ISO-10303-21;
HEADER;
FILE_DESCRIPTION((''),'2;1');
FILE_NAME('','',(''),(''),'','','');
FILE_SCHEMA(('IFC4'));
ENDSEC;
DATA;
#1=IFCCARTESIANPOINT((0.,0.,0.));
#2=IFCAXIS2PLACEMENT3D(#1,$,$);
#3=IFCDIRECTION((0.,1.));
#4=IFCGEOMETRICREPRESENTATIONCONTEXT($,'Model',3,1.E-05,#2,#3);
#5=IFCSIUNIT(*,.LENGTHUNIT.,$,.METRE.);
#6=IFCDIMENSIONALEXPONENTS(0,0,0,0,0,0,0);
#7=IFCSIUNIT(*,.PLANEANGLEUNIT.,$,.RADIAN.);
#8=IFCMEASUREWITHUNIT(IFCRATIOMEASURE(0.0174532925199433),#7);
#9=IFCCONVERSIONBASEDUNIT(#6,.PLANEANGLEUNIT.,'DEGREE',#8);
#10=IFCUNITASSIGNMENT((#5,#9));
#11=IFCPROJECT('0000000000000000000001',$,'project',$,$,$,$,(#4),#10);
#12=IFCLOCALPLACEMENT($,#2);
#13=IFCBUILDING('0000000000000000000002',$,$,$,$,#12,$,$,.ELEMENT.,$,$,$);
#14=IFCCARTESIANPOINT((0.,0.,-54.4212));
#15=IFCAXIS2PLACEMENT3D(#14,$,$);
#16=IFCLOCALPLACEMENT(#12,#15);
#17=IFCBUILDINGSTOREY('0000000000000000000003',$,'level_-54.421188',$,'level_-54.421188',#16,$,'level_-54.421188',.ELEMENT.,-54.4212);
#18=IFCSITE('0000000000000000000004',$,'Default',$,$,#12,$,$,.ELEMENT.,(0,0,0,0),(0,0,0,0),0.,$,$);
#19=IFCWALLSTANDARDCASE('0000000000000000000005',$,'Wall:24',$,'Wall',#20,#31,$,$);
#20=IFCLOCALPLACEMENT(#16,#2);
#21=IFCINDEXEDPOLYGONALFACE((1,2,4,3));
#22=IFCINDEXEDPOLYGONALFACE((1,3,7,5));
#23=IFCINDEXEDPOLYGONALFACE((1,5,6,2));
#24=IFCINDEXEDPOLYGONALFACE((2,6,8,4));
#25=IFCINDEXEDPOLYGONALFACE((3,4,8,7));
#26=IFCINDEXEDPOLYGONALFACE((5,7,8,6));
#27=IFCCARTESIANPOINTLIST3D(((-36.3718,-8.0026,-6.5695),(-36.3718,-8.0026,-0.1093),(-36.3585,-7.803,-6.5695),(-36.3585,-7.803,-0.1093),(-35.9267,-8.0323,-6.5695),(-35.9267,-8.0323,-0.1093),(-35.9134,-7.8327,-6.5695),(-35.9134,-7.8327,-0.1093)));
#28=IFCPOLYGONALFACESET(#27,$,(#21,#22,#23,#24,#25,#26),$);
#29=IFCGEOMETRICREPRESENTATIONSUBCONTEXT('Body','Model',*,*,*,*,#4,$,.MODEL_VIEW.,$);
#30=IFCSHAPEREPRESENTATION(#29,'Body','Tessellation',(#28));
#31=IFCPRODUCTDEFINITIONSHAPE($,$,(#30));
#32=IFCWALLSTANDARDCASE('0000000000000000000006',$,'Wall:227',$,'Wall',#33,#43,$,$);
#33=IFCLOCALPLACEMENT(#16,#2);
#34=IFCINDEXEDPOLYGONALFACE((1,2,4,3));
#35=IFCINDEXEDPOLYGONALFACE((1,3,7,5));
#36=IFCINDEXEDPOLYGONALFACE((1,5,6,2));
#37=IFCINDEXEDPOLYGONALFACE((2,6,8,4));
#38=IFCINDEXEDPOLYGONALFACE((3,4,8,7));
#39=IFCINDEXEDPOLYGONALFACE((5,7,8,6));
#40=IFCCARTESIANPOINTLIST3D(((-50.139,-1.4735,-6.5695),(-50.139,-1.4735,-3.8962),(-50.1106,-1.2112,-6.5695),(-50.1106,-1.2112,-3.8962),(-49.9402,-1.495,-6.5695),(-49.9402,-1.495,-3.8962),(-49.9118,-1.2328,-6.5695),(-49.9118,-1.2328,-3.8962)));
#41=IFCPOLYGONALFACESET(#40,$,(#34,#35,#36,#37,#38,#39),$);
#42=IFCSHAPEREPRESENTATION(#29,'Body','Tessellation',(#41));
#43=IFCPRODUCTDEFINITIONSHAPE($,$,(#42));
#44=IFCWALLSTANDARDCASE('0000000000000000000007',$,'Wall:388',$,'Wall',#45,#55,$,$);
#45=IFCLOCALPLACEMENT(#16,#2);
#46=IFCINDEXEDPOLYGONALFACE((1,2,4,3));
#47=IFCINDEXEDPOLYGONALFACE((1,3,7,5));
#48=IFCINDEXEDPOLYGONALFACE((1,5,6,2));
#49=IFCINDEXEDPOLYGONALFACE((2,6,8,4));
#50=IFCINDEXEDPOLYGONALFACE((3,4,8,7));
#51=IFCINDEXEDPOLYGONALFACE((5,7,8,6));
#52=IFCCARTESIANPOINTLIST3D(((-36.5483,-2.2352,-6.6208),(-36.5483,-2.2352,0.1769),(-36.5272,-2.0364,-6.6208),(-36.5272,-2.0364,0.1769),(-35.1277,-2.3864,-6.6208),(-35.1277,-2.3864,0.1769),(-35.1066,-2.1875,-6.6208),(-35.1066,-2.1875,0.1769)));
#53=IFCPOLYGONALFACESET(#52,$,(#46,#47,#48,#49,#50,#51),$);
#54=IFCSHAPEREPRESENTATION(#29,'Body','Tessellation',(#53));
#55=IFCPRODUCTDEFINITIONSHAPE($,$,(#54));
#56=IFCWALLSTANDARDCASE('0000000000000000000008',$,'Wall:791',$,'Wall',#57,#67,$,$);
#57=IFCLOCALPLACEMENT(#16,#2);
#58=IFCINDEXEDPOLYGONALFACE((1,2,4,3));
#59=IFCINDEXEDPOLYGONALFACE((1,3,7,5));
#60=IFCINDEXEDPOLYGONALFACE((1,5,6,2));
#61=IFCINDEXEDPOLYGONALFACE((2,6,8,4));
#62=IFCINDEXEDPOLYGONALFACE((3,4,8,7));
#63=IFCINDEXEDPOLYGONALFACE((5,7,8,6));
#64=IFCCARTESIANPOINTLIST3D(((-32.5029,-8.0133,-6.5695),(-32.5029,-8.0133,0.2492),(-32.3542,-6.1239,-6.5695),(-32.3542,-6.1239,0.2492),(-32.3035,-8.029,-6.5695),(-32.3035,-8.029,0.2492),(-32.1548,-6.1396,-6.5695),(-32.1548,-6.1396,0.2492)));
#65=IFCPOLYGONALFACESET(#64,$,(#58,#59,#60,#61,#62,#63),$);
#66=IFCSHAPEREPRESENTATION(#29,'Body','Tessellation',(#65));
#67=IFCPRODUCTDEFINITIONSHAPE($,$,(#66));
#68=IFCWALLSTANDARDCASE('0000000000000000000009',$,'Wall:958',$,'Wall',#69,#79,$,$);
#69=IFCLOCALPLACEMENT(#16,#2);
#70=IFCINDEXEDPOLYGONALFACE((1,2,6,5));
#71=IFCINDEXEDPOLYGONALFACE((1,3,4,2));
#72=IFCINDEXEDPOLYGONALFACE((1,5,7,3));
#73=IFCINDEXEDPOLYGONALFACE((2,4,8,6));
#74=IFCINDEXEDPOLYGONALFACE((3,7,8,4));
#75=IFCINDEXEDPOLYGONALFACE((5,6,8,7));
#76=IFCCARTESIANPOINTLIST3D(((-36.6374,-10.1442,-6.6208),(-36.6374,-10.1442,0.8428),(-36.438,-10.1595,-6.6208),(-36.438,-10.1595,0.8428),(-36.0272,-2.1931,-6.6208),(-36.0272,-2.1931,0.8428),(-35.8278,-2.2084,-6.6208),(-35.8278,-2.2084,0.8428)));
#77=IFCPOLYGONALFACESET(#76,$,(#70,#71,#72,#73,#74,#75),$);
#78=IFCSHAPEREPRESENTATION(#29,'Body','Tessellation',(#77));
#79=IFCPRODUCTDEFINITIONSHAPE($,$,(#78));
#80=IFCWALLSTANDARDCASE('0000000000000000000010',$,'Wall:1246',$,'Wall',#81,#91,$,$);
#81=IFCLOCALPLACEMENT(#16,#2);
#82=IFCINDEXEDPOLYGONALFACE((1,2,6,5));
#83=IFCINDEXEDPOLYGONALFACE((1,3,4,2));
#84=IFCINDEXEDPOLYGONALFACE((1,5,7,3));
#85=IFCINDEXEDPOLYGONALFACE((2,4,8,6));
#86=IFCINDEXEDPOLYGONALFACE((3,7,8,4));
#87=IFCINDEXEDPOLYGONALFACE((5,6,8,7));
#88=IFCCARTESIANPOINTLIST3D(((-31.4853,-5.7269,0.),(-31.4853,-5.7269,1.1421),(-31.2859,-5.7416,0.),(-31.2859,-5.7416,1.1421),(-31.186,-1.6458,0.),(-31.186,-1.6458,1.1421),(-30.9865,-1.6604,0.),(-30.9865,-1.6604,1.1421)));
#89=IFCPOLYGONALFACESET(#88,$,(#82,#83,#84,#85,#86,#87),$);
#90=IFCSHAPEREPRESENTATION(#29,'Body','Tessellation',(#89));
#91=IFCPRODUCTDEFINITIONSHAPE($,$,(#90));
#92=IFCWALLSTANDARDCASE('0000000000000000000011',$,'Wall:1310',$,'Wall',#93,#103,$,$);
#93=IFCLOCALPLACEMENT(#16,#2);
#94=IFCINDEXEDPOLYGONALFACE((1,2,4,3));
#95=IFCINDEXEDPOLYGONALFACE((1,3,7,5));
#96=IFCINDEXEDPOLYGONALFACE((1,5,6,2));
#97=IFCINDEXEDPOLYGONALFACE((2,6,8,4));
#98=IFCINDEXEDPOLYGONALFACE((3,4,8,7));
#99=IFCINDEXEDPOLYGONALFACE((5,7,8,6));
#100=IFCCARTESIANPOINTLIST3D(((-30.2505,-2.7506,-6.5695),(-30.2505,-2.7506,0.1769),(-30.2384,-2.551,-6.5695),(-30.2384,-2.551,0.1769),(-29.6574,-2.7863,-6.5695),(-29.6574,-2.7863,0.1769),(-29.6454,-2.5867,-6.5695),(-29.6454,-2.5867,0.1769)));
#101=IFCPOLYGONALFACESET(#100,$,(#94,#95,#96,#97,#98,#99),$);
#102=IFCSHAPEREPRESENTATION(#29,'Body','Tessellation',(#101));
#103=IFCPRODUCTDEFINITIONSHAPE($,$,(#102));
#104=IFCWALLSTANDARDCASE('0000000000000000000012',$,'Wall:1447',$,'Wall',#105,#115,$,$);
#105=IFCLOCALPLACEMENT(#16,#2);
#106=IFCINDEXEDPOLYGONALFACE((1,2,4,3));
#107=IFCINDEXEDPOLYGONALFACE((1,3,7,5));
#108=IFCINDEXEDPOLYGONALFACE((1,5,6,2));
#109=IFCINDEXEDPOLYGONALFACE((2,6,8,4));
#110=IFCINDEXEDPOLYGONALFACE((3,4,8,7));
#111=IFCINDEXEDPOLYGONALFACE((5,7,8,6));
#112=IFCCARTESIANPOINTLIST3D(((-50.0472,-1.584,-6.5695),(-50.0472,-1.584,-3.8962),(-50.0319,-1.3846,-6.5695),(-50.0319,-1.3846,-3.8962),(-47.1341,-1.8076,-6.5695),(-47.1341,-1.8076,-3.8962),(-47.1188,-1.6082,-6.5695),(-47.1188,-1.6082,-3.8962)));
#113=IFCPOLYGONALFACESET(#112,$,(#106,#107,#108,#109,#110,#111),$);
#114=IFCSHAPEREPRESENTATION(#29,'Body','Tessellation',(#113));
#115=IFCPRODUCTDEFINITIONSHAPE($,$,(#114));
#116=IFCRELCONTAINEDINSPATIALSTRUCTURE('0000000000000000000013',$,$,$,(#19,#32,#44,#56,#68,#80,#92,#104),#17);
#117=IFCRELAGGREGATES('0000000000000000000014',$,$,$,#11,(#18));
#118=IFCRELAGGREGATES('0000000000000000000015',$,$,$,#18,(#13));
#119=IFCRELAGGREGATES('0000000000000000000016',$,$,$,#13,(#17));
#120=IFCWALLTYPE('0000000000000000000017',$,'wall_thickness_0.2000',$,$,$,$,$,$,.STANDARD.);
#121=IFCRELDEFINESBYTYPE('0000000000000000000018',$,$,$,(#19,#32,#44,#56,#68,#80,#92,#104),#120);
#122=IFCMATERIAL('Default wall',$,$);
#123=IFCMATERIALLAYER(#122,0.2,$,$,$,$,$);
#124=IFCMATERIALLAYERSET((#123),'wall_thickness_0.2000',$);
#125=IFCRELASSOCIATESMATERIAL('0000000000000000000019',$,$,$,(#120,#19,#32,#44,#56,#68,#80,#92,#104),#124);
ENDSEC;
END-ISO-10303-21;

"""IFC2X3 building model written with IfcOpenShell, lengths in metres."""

from ifc_helpers import new_model, entity, si_unit, converted_unit, direction, frame, origin, place, context, subcontext, project, spatial, polyline, outline, extrude, material, layer, layer_set, layer_usage, type_object, element, save


model = new_model("IFC2X3")

# Units and contexts
model_context = context("Model", 3, precision=1e-05, world=origin(), true_north=direction((0.0, 1.0)))
body_context = subcontext(model_context, "Body", "Model", "MODEL_VIEW")
ifc_project = project(units=[si_unit("LENGTHUNIT", "METRE"), converted_unit("PLANEANGLEUNIT", "DEGREE", entity("IfcRatioMeasure", 0.0174532925199433), si_unit("PLANEANGLEUNIT", "RADIAN"), dimensions=[0, 0, 0, 0, 0, 0, 0])], contexts=[model_context])

# Site, building, storey
placement_1 = place(None, origin())
site = spatial("IfcSite", under=ifc_project, at=placement_1, Name="Default", CompositionType="ELEMENT", RefLatitude=(0, 0, 0, 0), RefLongitude=(0, 0, 0, 0), RefElevation=0.0)
building = spatial("IfcBuilding", under=site, at=placement_1, CompositionType="ELEMENT")
storey_placement = place(placement_1, frame((0.0, 0.0, -54.4212)))
storey = spatial("IfcBuildingStorey", under=building, at=storey_placement, Name="level_-54.421188", ObjectType="level_-54.421188", LongName="level_-54.421188", CompositionType="ELEMENT", Elevation=-54.4212)

# Walls
ifc_material_1 = material(Name="Default wall")
ifc_layer = layer(ifc_material_1, 0.2)
ifc_layer_set = layer_set([ifc_layer], Name="wall_thickness_0.2000")
ifc_layer_usage = layer_usage(ifc_layer_set, "AXIS2", "POSITIVE", -0.1)
wall_type = type_object("IfcWallType", Name="wall_thickness_0.2000", PredefinedType="STANDARD", material=ifc_layer_set)
placement_2 = place(placement_1, frame((0.0, 0.0, -60.9907)))
wall_1_placement = place(placement_2, frame((-35.9201, -7.9325, 0.0), z_axis=(0.0, 0.0, 1.0), x_axis=(-0.997776, 0.066649, 0.0)))
element("IfcWallStandardCase", 1, at=wall_1_placement, inside=storey, type_object=wall_type, material=ifc_layer_usage, Name="Wall:24", ObjectType="Wall", context=body_context, shape_type="SweptSolid", body=[
    extrude(outline(polyline([(0.4461, -0.1), (0.4461, 0.1), (0.0, 0.1), (0.0, -0.1), (0.4461, -0.1)])), origin(), (0.0, 0.0, 1.0), 6.4602),
])
placement_3 = place(placement_1, frame((0.0, 0.0, -60.9907)))
wall_2_placement = place(placement_3, frame((-50.0396, -1.4843, 0.0), z_axis=(0.0, 0.0, 1.0), x_axis=(0.107726, 0.994181, 0.0)))
element("IfcWallStandardCase", 2, at=wall_2_placement, inside=storey, type_object=wall_type, material=ifc_layer_usage, Name="Wall:227", ObjectType="Wall", context=body_context, shape_type="SweptSolid", body=[
    extrude(outline(polyline([(0.2638, -0.1), (0.2638, 0.1), (0.0, 0.1), (0.0, -0.1), (0.2638, -0.1)])), origin(), (0.0, 0.0, 1.0), 2.6733),
])
placement_4 = place(placement_1, frame((0.0, 0.0, -61.042)))
wall_3_placement = place(placement_4, frame((-35.1172, -2.2869, 0.0), z_axis=(0.0, 0.0, 1.0), x_axis=(-0.99439, 0.105778, 0.0)))
element("IfcWallStandardCase", 3, at=wall_3_placement, inside=storey, type_object=wall_type, material=ifc_layer_usage, Name="Wall:388", ObjectType="Wall", context=body_context, shape_type="SweptSolid", body=[
    extrude(outline(polyline([(1.4286, -0.1), (1.4286, 0.1), (0.0, 0.1), (0.0, -0.1), (1.4286, -0.1)])), origin(), (0.0, 0.0, 1.0), 6.7978),
])
placement_5 = place(placement_1, frame((0.0, 0.0, -60.9907)))
wall_4_placement = place(placement_5, frame((-32.2545, -6.1318, 0.0), z_axis=(0.0, 0.0, 1.0), x_axis=(-0.078422, -0.99692, 0.0)))
element("IfcWallStandardCase", 4, at=wall_4_placement, inside=storey, type_object=wall_type, material=ifc_layer_usage, Name="Wall:791", ObjectType="Wall", context=body_context, shape_type="SweptSolid", body=[
    extrude(outline(polyline([(1.8952, -0.1), (1.8952, 0.1), (0.0, 0.1), (0.0, -0.1), (1.8952, -0.1)])), origin(), (0.0, 0.0, 1.0), 6.8187),
])
placement_6 = place(placement_1, frame((0.0, 0.0, -61.042)))
wall_5_placement = place(placement_6, frame((-35.9275, -2.2007, 0.0), z_axis=(0.0, 0.0, 1.0), x_axis=(-0.076521, -0.997068, 0.0)))
element("IfcWallStandardCase", 5, at=wall_5_placement, inside=storey, type_object=wall_type, material=ifc_layer_usage, Name="Wall:958", ObjectType="Wall", context=body_context, shape_type="SweptSolid", body=[
    extrude(outline(polyline([(7.9745, -0.1), (7.9745, 0.1), (0.0, 0.1), (0.0, -0.1), (7.9745, -0.1)])), origin(), (0.0, 0.0, 1.0), 7.4637),
])
wall_6_placement = place(storey_placement, frame((-31.3856, -5.7343, 0.0), z_axis=(0.0, 0.0, 1.0), x_axis=(0.073153, 0.997321, 0.0)))
element("IfcWallStandardCase", 6, at=wall_6_placement, inside=storey, type_object=wall_type, material=ifc_layer_usage, Name="Wall:1246", ObjectType="Wall", context=body_context, shape_type="SweptSolid", body=[
    extrude(outline(polyline([(4.0921, -0.1), (4.0921, 0.1), (0.0, 0.1), (0.0, -0.1), (4.0921, -0.1)])), origin(), (0.0, 0.0, 1.0), 1.1421),
])
placement_7 = place(placement_1, frame((0.0, 0.0, -60.9907)))
wall_7_placement = place(placement_7, frame((-29.6514, -2.6865, 0.0), z_axis=(0.0, 0.0, 1.0), x_axis=(-0.998196, 0.060033, 0.0)))
element("IfcWallStandardCase", 7, at=wall_7_placement, inside=storey, type_object=wall_type, material=ifc_layer_usage, Name="Wall:1310", ObjectType="Wall", context=body_context, shape_type="SweptSolid", body=[
    extrude(outline(polyline([(0.5942, -0.1), (0.5942, 0.1), (0.0, 0.1), (0.0, -0.1), (0.5942, -0.1)])), origin(), (0.0, 0.0, 1.0), 6.7464),
])
placement_8 = place(placement_1, frame((0.0, 0.0, -60.9907)))
wall_8_placement = place(placement_8, frame((-47.1265, -1.7079, 0.0), z_axis=(0.0, 0.0, 1.0), x_axis=(-0.997066, 0.076552, 0.0)))
element("IfcWallStandardCase", 8, at=wall_8_placement, inside=storey, type_object=wall_type, material=ifc_layer_usage, Name="Wall:1447", ObjectType="Wall", context=body_context, shape_type="SweptSolid", body=[
    extrude(outline(polyline([(2.9217, -0.1), (2.9217, 0.1), (0.0, 0.1), (0.0, -0.1), (2.9217, -0.1)])), origin(), (0.0, 0.0, 1.0), 2.6733),
])

save(model, "model.ifc")
